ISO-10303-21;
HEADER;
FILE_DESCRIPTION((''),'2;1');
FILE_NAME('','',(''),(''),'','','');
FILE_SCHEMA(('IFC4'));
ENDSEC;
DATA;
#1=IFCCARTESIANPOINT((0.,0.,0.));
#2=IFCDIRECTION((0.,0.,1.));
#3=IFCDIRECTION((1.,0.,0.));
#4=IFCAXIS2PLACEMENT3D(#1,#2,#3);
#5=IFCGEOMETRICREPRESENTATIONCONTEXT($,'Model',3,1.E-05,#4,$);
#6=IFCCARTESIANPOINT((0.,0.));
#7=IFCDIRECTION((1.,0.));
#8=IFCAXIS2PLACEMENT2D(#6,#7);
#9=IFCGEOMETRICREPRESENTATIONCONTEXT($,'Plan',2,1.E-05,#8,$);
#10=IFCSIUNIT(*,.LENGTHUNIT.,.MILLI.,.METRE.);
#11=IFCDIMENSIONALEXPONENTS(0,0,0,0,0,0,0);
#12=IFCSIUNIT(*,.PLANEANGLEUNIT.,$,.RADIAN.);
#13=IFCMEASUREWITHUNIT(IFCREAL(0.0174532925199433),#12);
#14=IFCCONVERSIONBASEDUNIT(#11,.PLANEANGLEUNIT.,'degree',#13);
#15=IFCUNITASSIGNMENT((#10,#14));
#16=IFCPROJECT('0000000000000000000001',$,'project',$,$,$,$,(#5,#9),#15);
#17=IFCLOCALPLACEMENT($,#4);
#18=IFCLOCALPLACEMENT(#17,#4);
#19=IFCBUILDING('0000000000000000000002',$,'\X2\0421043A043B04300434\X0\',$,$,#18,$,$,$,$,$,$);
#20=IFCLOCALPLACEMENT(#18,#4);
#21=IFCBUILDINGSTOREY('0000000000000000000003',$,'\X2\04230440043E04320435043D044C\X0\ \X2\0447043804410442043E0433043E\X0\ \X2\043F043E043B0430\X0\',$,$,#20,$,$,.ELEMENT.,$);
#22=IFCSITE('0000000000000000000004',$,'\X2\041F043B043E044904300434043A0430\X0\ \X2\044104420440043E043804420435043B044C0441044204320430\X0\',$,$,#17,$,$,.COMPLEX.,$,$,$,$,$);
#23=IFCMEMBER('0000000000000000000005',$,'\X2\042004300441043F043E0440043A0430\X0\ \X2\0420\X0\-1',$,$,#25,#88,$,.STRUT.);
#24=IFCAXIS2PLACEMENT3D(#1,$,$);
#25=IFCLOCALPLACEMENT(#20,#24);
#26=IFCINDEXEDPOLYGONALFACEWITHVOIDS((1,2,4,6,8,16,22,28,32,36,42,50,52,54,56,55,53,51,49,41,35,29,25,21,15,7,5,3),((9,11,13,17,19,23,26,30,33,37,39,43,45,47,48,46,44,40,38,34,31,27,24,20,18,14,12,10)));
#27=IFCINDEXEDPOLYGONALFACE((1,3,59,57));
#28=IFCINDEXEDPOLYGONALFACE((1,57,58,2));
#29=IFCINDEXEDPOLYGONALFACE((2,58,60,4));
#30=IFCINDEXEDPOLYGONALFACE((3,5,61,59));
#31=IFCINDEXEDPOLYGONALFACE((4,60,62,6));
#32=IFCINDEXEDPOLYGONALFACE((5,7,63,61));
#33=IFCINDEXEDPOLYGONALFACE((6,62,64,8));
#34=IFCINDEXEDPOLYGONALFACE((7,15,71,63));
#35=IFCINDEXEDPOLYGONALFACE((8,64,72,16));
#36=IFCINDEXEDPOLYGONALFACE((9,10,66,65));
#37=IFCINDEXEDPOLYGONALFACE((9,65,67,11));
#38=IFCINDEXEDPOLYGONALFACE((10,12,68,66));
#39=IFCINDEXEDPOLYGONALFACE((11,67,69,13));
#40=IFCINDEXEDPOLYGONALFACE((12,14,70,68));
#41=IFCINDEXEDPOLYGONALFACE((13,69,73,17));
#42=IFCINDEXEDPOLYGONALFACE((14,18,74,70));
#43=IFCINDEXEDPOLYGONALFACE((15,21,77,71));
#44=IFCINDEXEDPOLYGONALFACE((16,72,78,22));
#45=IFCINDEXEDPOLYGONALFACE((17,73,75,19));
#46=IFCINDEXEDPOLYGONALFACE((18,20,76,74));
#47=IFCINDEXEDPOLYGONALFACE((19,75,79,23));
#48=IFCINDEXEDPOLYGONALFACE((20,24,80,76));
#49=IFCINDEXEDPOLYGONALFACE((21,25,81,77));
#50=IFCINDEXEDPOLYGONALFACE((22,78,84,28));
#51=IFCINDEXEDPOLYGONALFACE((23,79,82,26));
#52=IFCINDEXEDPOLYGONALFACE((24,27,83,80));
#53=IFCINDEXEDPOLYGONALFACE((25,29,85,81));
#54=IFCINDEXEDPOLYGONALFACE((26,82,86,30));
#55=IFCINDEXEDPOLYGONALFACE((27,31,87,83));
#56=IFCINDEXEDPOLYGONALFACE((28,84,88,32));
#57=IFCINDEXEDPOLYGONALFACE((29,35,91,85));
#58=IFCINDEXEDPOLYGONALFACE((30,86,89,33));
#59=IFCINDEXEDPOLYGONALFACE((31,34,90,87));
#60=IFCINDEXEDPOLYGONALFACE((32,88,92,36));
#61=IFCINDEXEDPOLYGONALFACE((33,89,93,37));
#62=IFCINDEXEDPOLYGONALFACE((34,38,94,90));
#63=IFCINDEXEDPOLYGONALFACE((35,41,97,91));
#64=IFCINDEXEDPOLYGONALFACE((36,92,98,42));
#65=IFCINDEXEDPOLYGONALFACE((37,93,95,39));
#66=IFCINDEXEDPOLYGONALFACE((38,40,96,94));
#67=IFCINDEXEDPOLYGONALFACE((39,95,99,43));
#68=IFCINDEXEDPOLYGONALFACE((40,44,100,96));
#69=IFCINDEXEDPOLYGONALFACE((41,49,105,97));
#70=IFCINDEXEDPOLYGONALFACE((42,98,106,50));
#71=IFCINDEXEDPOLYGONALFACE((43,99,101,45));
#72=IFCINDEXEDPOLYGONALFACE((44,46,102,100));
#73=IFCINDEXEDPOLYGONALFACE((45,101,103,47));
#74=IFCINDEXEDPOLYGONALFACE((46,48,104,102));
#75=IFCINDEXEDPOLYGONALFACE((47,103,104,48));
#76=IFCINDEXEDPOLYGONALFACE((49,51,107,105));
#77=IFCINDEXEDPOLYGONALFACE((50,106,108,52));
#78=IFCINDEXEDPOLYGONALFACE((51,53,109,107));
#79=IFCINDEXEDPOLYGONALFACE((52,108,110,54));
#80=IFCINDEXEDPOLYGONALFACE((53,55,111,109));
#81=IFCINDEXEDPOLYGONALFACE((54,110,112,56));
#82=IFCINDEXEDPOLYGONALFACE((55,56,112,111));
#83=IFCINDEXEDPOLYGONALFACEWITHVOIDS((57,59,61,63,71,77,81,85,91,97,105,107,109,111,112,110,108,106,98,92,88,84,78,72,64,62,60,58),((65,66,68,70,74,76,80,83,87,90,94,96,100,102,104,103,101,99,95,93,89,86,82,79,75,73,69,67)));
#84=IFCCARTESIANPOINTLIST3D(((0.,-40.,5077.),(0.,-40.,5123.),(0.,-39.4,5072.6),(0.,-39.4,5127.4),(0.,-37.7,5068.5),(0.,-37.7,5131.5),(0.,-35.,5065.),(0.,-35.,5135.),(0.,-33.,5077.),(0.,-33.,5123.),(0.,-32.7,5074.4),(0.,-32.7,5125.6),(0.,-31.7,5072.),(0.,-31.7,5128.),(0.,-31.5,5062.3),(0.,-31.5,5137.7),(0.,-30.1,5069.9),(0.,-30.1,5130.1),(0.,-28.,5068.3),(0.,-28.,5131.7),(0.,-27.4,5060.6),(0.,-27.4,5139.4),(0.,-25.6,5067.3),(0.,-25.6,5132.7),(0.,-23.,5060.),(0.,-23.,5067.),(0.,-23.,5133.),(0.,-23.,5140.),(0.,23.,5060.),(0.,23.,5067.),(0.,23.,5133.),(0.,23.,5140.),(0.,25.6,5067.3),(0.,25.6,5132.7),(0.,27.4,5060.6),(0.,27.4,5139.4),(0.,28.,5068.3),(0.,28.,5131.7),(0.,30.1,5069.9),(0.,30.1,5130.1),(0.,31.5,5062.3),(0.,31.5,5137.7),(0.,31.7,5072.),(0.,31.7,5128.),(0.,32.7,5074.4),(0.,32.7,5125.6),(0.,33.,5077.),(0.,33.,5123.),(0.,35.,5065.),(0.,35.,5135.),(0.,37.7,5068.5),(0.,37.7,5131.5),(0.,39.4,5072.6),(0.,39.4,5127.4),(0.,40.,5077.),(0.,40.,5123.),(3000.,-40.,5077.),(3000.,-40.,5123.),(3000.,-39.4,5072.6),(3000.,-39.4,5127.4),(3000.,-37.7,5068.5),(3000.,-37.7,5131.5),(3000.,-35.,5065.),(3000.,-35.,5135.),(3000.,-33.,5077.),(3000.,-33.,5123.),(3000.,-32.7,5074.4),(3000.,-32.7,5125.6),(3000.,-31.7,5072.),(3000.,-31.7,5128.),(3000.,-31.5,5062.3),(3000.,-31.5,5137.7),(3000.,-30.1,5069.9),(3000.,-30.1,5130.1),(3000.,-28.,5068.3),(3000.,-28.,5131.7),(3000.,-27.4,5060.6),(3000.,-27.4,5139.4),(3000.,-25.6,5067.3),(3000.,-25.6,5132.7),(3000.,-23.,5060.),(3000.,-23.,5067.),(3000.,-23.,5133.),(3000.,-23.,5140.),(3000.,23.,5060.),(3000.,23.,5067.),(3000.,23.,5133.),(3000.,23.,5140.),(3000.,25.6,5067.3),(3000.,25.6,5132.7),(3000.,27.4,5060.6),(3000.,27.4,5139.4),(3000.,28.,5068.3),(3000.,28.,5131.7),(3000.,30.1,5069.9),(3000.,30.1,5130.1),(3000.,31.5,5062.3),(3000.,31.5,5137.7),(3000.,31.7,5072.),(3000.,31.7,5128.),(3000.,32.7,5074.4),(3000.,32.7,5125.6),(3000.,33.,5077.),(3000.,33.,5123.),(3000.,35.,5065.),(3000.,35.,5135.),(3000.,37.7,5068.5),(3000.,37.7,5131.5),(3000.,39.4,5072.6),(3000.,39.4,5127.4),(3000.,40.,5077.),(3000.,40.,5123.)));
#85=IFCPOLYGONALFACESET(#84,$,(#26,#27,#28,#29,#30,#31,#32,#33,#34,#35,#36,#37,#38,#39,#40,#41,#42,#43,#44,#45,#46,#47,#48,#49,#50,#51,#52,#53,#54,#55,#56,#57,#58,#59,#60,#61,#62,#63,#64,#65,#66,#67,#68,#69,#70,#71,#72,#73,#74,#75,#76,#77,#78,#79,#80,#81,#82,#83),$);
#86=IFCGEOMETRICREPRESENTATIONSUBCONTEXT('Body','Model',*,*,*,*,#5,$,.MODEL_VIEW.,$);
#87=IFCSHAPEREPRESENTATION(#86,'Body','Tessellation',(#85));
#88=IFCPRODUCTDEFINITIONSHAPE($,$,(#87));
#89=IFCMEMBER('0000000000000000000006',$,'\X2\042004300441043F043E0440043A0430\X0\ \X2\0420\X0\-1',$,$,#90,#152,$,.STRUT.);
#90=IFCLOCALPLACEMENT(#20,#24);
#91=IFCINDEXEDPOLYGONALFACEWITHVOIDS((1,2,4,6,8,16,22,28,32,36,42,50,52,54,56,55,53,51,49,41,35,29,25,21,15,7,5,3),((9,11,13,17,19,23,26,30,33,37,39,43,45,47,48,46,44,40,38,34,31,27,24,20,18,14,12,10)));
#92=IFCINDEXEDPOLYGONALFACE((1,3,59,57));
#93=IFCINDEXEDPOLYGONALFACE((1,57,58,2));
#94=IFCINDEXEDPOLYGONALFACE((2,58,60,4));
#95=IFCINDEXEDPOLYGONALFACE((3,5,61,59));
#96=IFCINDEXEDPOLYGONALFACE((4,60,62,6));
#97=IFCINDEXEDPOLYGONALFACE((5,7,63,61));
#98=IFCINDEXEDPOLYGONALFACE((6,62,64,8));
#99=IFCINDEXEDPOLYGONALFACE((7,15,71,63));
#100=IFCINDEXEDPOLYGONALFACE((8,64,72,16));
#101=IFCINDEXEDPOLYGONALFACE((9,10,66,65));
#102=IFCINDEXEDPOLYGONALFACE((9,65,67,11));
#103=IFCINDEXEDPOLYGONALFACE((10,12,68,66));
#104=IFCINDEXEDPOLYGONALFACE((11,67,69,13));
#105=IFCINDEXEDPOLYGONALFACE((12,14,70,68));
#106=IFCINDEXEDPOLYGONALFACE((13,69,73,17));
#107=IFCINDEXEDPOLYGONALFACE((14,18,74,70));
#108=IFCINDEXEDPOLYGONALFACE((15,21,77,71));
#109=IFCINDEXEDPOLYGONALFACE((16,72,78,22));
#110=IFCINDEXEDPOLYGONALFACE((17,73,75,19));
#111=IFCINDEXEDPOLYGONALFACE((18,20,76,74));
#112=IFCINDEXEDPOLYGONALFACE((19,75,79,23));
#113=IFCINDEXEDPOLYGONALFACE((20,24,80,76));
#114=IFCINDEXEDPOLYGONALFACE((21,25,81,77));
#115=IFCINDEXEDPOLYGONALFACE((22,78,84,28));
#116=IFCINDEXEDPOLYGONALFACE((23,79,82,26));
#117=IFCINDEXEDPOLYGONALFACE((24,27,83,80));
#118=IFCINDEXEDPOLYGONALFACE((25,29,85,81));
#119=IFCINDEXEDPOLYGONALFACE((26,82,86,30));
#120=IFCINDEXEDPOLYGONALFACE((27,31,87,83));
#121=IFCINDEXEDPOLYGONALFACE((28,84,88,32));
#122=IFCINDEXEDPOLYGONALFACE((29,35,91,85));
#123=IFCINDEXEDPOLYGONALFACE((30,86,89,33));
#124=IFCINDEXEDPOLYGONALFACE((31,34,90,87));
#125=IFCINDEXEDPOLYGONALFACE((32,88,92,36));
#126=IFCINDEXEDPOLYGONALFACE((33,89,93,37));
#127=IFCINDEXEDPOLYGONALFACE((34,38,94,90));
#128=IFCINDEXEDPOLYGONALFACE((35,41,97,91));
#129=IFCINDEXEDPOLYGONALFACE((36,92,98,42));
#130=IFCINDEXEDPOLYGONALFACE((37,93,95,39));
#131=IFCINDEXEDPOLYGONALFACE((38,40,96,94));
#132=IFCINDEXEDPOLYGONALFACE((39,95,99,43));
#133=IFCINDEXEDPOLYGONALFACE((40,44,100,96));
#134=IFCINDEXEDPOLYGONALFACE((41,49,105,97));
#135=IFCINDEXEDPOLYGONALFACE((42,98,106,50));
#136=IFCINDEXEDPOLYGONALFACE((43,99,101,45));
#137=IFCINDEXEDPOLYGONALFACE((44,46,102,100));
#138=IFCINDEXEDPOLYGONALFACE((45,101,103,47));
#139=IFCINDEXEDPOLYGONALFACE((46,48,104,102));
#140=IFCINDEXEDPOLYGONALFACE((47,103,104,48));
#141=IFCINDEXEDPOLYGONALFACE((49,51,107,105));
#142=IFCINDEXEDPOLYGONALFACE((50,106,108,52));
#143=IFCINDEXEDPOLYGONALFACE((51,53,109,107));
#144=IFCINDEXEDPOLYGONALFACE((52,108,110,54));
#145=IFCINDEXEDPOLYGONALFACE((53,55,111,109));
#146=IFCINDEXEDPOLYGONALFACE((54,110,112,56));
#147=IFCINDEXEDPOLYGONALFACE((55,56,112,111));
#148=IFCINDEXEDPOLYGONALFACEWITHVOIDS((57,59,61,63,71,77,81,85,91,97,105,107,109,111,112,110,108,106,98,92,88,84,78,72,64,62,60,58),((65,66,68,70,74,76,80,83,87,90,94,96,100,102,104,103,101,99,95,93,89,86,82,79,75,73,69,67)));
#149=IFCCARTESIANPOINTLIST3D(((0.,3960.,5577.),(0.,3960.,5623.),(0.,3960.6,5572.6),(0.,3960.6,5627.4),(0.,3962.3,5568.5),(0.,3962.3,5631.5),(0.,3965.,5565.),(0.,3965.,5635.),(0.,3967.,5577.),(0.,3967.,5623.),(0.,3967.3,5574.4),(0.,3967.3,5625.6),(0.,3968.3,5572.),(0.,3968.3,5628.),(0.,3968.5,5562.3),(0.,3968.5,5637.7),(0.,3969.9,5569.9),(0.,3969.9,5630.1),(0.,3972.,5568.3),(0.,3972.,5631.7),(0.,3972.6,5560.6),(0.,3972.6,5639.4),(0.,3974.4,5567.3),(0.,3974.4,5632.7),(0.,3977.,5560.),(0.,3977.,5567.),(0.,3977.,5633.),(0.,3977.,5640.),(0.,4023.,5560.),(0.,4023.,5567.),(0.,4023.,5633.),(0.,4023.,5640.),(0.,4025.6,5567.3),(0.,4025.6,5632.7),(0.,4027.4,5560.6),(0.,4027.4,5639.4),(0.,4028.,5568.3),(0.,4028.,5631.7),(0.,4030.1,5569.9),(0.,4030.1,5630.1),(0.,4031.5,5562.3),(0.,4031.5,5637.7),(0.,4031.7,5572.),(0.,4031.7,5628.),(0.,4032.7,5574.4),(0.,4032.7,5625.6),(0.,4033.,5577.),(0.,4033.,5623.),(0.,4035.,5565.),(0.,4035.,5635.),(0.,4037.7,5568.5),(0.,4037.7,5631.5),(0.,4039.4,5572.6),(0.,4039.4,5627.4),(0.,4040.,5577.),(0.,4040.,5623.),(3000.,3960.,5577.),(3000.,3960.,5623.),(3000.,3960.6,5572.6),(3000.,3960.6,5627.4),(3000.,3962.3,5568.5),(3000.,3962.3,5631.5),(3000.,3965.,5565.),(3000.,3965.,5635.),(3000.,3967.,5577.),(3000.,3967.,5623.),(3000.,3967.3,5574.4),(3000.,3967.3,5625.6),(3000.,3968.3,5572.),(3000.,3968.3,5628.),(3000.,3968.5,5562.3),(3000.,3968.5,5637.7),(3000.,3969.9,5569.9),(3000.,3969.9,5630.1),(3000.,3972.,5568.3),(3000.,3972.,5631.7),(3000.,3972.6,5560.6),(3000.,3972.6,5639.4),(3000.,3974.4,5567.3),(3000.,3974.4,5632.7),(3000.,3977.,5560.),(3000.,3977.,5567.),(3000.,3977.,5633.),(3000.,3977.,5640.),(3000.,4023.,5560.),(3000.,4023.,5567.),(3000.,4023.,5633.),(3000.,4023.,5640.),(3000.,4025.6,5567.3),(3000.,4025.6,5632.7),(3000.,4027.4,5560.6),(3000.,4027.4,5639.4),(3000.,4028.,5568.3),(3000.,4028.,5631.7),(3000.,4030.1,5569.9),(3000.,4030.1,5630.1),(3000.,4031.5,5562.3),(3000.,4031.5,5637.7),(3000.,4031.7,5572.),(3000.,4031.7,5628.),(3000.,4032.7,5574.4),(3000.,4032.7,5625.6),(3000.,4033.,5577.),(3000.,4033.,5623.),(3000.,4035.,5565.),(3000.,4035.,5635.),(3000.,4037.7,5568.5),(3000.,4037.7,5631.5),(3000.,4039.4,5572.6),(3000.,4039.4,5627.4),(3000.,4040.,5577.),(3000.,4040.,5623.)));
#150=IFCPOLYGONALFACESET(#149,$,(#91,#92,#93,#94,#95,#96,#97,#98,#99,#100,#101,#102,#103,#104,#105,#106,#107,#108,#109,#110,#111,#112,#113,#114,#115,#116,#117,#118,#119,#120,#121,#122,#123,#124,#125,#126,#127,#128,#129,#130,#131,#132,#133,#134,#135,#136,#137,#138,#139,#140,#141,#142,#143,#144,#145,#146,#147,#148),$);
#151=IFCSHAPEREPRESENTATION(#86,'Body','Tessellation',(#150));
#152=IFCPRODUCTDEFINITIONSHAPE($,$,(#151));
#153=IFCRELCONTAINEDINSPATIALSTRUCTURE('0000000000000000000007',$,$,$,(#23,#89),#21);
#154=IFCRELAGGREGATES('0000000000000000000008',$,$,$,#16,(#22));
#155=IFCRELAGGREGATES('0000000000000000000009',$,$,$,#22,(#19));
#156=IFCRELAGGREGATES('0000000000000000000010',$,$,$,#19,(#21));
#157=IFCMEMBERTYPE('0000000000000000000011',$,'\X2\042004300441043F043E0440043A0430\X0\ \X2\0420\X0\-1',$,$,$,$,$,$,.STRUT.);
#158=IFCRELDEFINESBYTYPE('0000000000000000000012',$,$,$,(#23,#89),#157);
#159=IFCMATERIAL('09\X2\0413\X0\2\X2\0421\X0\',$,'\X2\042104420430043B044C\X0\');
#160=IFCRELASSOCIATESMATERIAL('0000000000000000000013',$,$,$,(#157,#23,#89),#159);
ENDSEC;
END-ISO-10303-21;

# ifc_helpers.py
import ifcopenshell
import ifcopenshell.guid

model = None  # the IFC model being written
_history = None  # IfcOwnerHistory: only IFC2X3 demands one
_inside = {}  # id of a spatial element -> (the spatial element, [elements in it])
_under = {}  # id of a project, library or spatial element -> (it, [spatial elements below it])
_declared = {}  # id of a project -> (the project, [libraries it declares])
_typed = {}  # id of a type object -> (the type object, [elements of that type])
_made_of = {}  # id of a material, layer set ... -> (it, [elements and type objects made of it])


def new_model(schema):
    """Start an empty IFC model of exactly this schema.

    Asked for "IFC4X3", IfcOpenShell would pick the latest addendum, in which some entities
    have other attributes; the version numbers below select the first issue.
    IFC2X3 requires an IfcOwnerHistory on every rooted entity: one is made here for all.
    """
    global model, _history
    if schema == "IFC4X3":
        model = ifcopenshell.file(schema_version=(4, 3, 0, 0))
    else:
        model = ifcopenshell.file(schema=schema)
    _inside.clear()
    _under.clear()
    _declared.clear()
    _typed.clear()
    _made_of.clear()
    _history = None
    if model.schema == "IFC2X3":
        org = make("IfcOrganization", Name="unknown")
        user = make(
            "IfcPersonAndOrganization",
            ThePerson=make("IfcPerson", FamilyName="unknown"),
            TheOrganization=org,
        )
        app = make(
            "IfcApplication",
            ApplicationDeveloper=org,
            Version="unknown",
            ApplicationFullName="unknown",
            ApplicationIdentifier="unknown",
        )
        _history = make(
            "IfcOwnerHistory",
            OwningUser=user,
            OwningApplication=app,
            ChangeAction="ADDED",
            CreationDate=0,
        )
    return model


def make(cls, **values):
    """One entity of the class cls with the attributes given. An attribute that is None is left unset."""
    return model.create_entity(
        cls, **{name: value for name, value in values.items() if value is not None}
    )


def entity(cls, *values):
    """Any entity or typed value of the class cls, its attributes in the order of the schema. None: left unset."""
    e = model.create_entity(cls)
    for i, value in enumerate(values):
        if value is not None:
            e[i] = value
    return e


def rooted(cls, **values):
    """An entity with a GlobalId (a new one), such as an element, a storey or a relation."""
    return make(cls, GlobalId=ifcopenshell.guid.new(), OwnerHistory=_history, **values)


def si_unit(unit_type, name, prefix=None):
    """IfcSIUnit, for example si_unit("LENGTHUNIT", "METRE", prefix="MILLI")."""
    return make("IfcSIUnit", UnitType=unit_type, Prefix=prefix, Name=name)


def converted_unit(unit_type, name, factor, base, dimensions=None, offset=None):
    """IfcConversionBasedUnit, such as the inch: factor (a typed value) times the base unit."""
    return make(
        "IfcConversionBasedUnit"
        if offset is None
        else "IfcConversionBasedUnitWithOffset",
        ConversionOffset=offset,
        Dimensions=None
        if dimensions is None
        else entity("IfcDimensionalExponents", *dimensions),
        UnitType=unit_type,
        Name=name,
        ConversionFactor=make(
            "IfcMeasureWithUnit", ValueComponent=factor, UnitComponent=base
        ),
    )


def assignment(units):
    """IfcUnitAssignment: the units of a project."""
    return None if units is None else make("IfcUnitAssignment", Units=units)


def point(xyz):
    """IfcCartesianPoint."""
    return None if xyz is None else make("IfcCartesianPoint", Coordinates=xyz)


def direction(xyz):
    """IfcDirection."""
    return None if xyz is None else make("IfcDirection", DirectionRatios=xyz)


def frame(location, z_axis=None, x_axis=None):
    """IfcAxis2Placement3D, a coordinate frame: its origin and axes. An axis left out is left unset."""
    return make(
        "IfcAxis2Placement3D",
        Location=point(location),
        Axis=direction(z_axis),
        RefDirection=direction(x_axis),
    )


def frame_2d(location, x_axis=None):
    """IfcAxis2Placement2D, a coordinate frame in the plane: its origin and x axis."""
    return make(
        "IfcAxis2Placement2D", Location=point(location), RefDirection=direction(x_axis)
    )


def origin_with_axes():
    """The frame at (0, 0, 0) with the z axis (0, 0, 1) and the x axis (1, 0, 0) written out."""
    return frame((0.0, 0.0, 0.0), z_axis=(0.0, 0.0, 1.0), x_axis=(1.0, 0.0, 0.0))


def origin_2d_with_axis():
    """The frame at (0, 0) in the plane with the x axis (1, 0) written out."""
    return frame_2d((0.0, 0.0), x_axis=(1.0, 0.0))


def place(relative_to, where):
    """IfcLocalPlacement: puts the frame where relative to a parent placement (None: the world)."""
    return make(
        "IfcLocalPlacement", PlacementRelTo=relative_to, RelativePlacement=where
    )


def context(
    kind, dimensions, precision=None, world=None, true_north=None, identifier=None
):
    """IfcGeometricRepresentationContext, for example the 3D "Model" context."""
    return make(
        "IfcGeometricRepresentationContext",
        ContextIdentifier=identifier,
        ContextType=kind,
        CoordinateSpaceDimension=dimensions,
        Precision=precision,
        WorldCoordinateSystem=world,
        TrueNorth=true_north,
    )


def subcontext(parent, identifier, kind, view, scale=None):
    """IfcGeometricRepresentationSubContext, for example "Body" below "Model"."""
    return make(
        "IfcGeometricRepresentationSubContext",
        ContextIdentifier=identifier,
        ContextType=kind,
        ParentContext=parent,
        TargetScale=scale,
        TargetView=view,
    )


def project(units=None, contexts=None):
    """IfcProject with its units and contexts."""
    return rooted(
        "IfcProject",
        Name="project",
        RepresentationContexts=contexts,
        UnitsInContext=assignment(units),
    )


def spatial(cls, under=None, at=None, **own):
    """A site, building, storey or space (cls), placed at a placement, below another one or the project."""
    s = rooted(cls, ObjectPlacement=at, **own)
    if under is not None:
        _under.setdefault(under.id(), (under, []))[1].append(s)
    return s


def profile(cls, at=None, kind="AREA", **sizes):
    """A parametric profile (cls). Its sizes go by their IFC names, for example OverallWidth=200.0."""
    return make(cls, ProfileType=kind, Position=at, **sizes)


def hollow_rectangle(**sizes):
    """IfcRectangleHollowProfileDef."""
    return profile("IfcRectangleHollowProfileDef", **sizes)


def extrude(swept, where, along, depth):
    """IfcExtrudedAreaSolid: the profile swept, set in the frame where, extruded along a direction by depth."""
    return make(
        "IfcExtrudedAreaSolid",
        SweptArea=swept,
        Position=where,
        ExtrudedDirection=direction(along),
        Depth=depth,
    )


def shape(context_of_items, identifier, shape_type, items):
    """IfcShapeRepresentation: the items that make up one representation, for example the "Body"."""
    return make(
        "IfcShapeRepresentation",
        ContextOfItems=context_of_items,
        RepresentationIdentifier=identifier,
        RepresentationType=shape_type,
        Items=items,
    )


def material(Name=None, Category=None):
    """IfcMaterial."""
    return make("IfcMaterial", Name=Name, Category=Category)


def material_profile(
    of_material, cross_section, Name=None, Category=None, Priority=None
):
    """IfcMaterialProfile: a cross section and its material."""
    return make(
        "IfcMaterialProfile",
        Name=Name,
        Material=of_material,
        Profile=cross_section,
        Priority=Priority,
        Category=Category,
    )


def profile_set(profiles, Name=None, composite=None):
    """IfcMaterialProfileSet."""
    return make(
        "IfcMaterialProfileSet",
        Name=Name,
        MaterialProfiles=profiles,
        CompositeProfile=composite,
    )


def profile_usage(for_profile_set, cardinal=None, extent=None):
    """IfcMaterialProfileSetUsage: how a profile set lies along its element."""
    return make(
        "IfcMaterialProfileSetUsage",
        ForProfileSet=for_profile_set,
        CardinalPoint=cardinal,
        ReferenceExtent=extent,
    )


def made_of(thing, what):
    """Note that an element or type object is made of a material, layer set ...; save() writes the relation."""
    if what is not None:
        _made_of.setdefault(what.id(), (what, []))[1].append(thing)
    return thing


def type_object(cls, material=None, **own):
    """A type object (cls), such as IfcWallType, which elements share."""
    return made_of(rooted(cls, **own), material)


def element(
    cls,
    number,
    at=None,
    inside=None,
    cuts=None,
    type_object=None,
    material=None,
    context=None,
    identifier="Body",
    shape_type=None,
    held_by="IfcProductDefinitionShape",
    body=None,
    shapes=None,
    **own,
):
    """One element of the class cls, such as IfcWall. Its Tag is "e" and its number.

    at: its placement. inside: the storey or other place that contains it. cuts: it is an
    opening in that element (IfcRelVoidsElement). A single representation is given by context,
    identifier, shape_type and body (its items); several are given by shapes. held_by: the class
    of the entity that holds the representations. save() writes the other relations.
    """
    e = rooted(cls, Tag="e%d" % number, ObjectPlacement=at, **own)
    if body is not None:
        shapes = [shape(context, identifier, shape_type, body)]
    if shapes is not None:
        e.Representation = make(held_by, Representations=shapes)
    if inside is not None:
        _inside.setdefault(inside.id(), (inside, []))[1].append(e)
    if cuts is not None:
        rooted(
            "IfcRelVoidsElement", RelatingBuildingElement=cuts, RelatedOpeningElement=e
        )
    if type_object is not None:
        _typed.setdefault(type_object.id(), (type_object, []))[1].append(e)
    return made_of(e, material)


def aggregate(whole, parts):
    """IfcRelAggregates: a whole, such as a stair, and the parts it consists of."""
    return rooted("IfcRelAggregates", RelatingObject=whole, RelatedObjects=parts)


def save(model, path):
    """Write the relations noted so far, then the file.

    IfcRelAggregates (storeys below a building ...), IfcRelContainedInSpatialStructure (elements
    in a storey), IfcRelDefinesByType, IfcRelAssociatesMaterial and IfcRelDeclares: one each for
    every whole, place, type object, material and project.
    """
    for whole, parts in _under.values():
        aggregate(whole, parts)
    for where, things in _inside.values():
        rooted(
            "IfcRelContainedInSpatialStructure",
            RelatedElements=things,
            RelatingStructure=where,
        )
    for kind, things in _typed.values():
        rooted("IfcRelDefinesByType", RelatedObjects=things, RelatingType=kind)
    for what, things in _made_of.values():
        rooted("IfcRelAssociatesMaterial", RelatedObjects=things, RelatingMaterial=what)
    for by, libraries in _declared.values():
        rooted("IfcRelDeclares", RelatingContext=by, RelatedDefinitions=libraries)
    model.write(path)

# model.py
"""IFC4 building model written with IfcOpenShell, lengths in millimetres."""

from ifc_helpers import new_model, entity, si_unit, converted_unit, frame, origin_with_axes, origin_2d_with_axis, place, context, subcontext, project, spatial, hollow_rectangle, extrude, material, material_profile, profile_set, profile_usage, type_object, element, save


model = new_model("IFC4")

# Units and contexts
model_context = context("Model", 3, precision=1e-05, world=origin_with_axes())
plan_context = context("Plan", 2, precision=1e-05, world=origin_2d_with_axis())
body_context = subcontext(model_context, "Body", "Model", "MODEL_VIEW")
ifc_project = project(units=[si_unit("LENGTHUNIT", "METRE", prefix="MILLI"), converted_unit("PLANEANGLEUNIT", "degree", entity("IfcReal", 0.0174532925199433), si_unit("PLANEANGLEUNIT", "RADIAN"), dimensions=[0, 0, 0, 0, 0, 0, 0])], contexts=[model_context, plan_context])

# Site, building, storey
site_placement = place(None, origin_with_axes())
site = spatial("IfcSite", under=ifc_project, at=site_placement, Name="Площадка строительства", CompositionType="COMPLEX")
building_placement = place(site_placement, origin_with_axes())
building = spatial("IfcBuilding", under=site, at=building_placement, Name="Склад")
storey_placement = place(building_placement, origin_with_axes())
storey = spatial("IfcBuildingStorey", under=building, at=storey_placement, Name="Уровень чистого пола", CompositionType="ELEMENT")

# Members
ifc_material_1 = material(Name="09Г2С", Category="Сталь")
ifc_material_profile_1 = material_profile(ifc_material_1, hollow_rectangle(XDim=80.0, YDim=80.0, WallThickness=7.0, InnerFilletRadius=10.0, OuterFilletRadius=17.0))
ifc_profile_set_1 = profile_set([ifc_material_profile_1], Name="PK80x7_09G2S")
member_type_1 = type_object("IfcMemberType", Name="Распорка Р-1", PredefinedType="STRUT", material=ifc_profile_set_1)
ifc_profile_usage_1 = profile_usage(ifc_profile_set_1, cardinal=5)
member_1_placement = place(storey_placement, frame((0.0, 0.0, 5100.0), z_axis=(1.0, 0.0, 0.0), x_axis=(0.0, 1.0, 0.0)))
element("IfcMember", 1, at=member_1_placement, inside=storey, type_object=member_type_1, material=ifc_profile_usage_1, Name="Распорка Р-1", PredefinedType="STRUT", context=body_context, shape_type="SweptSolid", body=[
    extrude(hollow_rectangle(XDim=80.0, YDim=80.0, WallThickness=7.0, InnerFilletRadius=10.0, OuterFilletRadius=17.0), origin_with_axes(), (0.0, 0.0, 1.0), 3000.0),
])
ifc_profile_usage_2 = profile_usage(ifc_profile_set_1, cardinal=5)
member_2_placement = place(storey_placement, frame((0.0, 4000.0, 5600.0), z_axis=(1.0, 0.0, 0.0), x_axis=(0.0, 1.0, 0.0)))
element("IfcMember", 2, at=member_2_placement, inside=storey, type_object=member_type_1, material=ifc_profile_usage_2, Name="Распорка Р-1", PredefinedType="STRUT", context=body_context, shape_type="SweptSolid", body=[
    extrude(hollow_rectangle(XDim=80.0, YDim=80.0, WallThickness=7.0, InnerFilletRadius=10.0, OuterFilletRadius=17.0), origin_with_axes(), (0.0, 0.0, 1.0), 3000.0),
])

save(model, "model.ifc")
